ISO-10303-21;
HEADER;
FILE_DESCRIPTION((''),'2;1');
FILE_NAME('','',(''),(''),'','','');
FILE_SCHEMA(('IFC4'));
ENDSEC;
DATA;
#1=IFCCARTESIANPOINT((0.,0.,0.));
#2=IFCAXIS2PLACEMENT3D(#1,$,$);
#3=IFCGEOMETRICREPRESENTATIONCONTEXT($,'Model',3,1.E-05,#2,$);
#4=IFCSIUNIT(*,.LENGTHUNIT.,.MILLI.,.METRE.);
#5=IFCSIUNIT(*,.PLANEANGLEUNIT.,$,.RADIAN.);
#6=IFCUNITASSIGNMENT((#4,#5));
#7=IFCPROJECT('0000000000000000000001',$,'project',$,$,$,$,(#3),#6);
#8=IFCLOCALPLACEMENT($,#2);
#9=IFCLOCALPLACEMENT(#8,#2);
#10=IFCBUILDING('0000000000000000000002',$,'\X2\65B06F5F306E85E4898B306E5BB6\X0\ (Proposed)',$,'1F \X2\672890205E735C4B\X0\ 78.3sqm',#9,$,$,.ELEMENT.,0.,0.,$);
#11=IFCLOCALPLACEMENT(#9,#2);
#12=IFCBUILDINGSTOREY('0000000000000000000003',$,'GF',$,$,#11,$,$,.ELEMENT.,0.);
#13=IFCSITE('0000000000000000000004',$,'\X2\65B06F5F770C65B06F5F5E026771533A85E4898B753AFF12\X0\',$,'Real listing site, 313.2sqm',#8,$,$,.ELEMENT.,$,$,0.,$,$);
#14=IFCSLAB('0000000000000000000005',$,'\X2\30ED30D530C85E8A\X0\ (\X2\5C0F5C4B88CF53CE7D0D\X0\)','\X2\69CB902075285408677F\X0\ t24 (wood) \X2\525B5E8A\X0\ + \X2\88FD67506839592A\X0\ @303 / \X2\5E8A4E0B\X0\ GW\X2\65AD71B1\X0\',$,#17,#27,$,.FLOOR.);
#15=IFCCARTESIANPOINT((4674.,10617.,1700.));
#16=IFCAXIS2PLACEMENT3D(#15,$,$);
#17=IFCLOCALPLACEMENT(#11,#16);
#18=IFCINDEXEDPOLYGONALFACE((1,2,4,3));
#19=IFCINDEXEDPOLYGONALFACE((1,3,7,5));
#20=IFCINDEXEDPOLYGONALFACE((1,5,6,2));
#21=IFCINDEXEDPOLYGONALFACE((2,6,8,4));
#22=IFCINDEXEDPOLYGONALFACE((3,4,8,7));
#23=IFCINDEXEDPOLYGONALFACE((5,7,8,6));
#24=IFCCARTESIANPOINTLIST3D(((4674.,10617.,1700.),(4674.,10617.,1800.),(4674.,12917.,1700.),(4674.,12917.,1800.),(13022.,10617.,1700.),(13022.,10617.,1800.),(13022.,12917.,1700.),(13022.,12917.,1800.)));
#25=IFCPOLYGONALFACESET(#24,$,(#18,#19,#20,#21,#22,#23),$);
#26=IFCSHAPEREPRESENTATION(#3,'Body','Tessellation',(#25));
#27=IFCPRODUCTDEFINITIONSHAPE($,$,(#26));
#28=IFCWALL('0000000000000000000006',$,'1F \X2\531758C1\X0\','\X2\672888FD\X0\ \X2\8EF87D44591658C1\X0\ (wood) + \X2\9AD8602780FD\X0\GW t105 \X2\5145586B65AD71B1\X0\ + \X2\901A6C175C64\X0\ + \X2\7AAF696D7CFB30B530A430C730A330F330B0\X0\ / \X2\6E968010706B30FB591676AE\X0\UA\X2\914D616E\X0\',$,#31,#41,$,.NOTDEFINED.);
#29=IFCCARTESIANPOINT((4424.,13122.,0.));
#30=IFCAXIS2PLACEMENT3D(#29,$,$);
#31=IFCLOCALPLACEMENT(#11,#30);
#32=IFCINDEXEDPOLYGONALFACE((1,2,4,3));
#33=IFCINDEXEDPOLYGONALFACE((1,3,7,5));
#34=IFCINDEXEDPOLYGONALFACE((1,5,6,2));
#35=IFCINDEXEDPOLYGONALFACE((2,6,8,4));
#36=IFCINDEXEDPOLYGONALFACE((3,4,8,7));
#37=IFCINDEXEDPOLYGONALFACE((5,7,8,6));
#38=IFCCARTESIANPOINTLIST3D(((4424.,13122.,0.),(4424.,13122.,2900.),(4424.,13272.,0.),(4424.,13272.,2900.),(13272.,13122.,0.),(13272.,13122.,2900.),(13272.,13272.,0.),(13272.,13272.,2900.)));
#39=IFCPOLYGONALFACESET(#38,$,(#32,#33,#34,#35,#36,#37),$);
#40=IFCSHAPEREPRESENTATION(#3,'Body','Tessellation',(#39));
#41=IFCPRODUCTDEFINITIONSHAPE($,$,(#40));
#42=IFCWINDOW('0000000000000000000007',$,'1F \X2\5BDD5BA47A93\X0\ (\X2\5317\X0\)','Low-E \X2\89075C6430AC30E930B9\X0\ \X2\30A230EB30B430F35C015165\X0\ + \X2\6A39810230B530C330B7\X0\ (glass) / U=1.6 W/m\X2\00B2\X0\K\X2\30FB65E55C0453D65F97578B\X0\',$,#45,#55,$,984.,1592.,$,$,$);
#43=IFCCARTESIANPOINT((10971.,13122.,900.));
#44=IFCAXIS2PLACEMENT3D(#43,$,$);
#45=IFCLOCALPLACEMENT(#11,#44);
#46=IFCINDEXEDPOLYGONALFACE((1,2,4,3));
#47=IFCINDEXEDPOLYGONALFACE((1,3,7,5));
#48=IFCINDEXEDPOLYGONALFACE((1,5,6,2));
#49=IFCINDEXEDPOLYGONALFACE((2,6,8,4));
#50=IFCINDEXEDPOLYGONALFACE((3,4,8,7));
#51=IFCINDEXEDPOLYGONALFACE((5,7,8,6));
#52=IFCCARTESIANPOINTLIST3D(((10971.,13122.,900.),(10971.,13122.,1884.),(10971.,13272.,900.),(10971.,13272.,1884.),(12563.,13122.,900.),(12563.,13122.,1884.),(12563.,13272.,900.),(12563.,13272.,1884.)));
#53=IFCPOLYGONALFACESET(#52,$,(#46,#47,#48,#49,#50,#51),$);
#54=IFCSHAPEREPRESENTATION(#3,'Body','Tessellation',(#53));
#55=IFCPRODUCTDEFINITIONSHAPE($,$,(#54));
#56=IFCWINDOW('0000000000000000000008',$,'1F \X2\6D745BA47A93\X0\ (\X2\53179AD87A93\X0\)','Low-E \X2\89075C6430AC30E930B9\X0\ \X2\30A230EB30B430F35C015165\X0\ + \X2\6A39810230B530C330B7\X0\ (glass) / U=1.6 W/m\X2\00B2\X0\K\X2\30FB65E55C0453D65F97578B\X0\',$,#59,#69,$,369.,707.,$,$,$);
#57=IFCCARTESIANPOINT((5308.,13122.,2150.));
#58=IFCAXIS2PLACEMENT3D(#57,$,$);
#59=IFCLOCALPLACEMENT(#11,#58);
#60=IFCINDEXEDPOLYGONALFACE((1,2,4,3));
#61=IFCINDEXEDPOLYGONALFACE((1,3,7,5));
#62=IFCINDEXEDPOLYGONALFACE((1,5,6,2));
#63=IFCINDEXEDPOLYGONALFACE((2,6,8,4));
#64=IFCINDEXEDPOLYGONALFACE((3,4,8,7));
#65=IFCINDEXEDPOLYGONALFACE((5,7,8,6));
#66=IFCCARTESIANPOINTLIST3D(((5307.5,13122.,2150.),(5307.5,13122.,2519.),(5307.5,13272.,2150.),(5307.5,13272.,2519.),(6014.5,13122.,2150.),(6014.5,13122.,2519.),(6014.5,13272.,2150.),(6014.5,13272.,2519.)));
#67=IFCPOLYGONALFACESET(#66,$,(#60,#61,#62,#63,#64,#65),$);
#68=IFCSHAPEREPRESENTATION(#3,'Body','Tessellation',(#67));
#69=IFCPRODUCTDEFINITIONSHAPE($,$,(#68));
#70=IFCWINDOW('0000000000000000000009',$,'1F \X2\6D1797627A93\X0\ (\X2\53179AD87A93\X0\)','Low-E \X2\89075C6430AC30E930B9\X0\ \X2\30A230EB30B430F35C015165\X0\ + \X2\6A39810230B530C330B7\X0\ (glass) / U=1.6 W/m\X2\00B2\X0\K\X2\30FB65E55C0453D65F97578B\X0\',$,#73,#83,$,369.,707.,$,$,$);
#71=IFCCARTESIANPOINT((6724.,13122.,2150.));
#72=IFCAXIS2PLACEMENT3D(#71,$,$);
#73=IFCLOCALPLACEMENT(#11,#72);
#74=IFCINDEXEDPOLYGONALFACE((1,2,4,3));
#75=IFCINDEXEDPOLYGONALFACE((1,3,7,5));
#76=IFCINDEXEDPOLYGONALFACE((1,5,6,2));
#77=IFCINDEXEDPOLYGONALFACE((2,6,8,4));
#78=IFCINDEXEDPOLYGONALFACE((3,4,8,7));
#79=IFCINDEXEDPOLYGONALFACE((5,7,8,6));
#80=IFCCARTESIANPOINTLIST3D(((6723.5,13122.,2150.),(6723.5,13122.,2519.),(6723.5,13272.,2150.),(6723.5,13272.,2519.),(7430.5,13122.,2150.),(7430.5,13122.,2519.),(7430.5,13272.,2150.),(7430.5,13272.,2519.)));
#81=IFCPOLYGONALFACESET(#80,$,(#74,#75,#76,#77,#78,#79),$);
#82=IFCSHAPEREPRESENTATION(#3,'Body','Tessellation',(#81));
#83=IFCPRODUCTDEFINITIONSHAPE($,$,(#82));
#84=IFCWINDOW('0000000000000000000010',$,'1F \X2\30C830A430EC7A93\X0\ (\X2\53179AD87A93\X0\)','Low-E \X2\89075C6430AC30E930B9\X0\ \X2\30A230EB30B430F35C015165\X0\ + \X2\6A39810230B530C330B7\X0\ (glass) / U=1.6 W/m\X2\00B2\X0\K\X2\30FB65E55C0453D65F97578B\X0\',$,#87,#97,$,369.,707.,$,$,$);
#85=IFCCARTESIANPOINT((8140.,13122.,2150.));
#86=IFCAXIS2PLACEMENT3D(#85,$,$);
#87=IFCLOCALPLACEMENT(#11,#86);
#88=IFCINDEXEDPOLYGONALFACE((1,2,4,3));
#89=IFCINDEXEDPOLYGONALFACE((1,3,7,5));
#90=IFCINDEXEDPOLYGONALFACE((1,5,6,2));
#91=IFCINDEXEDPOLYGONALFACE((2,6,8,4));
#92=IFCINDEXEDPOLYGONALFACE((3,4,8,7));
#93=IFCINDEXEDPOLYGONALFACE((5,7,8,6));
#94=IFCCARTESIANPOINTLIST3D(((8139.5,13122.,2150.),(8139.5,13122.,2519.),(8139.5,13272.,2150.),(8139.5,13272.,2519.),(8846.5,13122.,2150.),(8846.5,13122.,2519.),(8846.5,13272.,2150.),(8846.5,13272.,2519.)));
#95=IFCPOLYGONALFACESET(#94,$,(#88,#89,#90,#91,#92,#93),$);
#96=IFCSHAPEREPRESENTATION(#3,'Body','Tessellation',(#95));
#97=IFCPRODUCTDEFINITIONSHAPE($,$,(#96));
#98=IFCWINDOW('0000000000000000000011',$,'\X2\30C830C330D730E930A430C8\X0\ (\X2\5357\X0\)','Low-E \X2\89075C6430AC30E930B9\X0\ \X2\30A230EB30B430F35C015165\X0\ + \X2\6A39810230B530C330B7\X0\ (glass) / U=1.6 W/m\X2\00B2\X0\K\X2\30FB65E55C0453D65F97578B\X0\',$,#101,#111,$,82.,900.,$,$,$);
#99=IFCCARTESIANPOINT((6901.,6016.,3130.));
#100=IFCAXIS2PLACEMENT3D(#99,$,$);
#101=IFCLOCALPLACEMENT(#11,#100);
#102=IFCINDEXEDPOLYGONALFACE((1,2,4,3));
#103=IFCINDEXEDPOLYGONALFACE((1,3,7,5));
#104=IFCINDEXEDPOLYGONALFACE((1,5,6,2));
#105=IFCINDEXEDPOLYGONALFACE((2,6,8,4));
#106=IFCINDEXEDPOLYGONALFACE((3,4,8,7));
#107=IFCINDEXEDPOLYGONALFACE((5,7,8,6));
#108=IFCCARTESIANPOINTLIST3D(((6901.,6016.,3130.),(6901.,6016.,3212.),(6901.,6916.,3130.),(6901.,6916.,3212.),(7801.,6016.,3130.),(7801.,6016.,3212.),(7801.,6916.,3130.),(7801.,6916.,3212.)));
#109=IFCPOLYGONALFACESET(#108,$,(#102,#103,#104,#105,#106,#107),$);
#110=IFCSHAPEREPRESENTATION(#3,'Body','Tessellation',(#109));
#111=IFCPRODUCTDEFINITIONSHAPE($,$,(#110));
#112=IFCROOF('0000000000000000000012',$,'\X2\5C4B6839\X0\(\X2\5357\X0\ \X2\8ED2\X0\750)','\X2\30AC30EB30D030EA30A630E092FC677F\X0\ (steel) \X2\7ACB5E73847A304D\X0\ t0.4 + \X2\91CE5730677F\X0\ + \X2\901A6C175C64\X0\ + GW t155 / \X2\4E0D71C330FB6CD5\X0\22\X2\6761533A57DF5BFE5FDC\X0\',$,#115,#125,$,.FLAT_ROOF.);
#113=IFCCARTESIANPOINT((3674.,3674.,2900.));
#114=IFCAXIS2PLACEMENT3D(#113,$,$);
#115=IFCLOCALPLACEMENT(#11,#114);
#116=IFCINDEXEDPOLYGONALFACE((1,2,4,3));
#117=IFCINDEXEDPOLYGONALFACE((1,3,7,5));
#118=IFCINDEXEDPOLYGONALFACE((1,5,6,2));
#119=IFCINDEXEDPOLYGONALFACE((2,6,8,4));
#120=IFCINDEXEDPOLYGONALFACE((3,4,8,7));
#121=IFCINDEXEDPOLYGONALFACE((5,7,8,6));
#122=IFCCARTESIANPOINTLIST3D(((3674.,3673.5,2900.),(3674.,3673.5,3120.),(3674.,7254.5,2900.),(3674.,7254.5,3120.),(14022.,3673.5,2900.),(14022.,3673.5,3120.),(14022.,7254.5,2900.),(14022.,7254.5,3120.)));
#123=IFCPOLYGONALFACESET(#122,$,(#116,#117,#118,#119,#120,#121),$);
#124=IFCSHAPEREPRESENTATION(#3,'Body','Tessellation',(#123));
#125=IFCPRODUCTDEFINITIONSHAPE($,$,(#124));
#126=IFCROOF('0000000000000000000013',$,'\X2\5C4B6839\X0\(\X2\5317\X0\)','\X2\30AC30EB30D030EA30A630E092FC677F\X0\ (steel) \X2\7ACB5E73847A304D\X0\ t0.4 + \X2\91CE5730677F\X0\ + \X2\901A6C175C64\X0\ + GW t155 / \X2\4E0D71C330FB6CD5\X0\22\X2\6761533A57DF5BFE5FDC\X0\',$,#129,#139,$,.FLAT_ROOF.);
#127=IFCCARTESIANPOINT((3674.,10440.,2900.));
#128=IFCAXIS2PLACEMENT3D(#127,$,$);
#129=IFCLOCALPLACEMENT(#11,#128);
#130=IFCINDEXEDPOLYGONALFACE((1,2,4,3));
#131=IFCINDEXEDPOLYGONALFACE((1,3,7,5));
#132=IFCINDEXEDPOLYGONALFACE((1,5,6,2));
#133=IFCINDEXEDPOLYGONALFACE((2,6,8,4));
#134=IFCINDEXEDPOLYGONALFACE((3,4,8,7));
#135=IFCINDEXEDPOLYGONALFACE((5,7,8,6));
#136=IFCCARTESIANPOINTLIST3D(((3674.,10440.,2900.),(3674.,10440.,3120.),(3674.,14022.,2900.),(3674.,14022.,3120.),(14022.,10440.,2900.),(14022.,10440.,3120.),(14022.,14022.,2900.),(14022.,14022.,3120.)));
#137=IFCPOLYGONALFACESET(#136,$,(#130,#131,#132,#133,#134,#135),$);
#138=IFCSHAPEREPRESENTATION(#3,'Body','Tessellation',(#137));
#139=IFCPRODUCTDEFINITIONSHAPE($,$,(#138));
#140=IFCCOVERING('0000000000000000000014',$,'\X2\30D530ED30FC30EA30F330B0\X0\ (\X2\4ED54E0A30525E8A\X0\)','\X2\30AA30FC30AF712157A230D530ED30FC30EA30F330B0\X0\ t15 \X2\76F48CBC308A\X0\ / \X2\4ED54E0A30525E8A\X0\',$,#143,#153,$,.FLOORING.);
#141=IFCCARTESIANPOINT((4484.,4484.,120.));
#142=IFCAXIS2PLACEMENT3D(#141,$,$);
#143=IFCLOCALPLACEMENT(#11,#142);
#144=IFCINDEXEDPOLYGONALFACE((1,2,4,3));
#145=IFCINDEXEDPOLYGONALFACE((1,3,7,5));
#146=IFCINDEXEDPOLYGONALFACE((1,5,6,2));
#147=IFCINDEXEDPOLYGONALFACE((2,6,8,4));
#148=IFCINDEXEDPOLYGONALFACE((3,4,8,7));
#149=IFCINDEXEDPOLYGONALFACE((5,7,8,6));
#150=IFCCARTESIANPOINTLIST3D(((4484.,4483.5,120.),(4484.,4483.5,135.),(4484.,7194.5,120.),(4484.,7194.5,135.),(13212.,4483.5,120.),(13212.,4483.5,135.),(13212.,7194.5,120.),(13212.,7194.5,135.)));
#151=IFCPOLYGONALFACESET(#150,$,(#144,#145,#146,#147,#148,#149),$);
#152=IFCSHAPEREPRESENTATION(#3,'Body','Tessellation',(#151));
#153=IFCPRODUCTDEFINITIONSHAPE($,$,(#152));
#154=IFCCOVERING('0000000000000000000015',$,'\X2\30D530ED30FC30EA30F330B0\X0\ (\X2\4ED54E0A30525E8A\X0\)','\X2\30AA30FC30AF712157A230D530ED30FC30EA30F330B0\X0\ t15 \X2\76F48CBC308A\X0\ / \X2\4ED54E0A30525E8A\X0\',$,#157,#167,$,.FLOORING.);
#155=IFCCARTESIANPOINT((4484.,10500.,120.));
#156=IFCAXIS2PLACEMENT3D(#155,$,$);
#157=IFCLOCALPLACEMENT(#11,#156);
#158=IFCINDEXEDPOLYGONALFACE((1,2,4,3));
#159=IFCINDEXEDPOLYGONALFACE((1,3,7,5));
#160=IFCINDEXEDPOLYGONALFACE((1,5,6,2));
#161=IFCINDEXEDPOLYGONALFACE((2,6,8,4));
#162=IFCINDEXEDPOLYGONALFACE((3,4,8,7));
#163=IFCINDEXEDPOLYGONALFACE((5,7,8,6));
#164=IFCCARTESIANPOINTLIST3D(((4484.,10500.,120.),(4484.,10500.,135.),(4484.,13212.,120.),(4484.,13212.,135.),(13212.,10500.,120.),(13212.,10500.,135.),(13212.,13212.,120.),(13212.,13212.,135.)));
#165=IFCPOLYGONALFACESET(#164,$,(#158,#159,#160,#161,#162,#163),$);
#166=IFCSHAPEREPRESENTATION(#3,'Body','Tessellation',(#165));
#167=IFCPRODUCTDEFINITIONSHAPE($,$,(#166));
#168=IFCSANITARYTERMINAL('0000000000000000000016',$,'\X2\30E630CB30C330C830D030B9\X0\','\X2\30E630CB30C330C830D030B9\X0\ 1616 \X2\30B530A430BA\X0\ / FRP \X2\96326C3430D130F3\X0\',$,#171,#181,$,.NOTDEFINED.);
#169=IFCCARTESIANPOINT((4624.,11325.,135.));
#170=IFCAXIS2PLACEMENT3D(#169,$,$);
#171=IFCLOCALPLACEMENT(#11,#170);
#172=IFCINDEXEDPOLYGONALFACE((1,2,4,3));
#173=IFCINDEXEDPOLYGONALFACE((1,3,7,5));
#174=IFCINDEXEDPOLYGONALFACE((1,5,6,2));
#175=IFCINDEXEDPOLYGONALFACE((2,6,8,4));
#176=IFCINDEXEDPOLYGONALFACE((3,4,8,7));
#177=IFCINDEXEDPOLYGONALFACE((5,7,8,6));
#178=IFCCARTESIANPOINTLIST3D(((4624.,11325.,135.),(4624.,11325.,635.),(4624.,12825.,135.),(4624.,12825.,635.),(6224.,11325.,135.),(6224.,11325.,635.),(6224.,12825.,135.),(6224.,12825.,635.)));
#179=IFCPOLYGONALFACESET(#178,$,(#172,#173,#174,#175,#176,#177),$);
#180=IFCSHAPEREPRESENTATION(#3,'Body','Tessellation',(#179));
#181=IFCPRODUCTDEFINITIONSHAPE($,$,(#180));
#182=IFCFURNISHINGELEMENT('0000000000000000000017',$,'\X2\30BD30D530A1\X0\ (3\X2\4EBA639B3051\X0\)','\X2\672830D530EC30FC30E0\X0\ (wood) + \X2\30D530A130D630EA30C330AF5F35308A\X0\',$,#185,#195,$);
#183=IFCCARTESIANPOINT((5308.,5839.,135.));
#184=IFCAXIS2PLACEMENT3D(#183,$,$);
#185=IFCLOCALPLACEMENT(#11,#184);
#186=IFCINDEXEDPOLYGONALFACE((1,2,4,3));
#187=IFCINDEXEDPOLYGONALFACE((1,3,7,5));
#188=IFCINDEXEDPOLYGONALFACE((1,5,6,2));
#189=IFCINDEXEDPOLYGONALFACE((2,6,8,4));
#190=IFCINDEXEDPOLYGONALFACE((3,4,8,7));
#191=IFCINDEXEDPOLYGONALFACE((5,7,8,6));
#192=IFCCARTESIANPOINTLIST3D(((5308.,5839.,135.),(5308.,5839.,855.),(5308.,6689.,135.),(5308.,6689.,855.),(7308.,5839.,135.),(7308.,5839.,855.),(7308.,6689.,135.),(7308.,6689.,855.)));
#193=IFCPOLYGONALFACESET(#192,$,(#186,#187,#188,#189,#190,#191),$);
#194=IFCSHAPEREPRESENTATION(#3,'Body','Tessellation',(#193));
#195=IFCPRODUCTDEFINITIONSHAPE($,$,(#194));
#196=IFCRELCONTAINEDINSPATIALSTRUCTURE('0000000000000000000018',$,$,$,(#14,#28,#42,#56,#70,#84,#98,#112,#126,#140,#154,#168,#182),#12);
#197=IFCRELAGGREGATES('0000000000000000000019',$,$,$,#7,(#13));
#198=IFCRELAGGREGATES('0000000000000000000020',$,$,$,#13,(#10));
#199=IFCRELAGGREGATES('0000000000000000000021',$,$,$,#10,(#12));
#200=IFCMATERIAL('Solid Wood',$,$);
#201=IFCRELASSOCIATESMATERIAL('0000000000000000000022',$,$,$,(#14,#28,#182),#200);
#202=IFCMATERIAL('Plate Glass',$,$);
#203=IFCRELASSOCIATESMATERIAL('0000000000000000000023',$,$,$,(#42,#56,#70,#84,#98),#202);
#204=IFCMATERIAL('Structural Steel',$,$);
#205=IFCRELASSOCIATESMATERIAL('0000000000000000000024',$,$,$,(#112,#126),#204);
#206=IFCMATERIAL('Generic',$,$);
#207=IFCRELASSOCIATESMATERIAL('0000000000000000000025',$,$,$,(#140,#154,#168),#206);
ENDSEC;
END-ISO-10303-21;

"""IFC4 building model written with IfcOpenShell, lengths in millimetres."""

from ifc_helpers import new_model, si_unit, frame, frame_2d, origin, place, context, project, spatial, rectangle, extrude, material, element, fill, save


model = new_model("IFC4")

# Units and contexts
model_context = context("Model", 3, precision=1e-05, world=origin())
ifc_project = project(units=[si_unit("LENGTHUNIT", "METRE", prefix="MILLI"), si_unit("PLANEANGLEUNIT", "RADIAN")], contexts=[model_context])

# Site, building, storey
site_placement = place(None, origin())
site = spatial("IfcSite", under=ifc_project, at=site_placement, Name="新潟県新潟市東区藤見町２", ObjectType="Real listing site, 313.2sqm", CompositionType="ELEMENT", RefElevation=0.0)
building_placement = place(site_placement, origin())
building = spatial("IfcBuilding", under=site, at=building_placement, Name="新潟の藤見の家 (Proposed)", ObjectType="1F 木造平屋 78.3sqm", CompositionType="ELEMENT", ElevationOfRefHeight=0.0, ElevationOfTerrain=0.0)
storey_placement = place(building_placement, origin())
storey = spatial("IfcBuildingStorey", under=building, at=storey_placement, Name="GF", CompositionType="ELEMENT", Elevation=0.0)

# Slab
ifc_material_1 = material(Name="Solid Wood")
slab_1_placement = place(storey_placement, frame((4674.0, 10617.0, 1700.0)))
element("IfcSlab", 1, at=slab_1_placement, inside=storey, material=ifc_material_1, Name="ロフト床 (小屋裏収納)", Description="構造用合板 t24 (wood) 剛床 + 製材根太 @303 / 床下 GW断熱", PredefinedType="FLOOR", context=model_context, shape_type="SweptSolid", body=[
    extrude(rectangle(XDim=8348.0, YDim=2300.0, at=frame_2d((4174.0, 1150.0))), frame((4674.0, 10617.0, 1700.0)), (0.0, 0.0, 1.0), 100.0),
])

# Shared definitions
ifc_material_2 = material(Name="Plate Glass")

# Wall, openings, windows
wall_1_placement = place(storey_placement, frame((4424.0, 13122.0, 0.0)))
wall_1 = element("IfcWall", 2, at=wall_1_placement, inside=storey, material=ifc_material_1, Name="1F 北壁", Description="木製 軸組外壁 (wood) + 高性能GW t105 充填断熱 + 通気層 + 窯業系サイディング / 準耐火・外皮UA配慮", PredefinedType="NOTDEFINED", context=model_context, shape_type="SweptSolid", body=[
    extrude(rectangle(XDim=8848.0, YDim=150.0, at=frame_2d((4424.0, 75.0))), frame((4424.0, 13122.0, 0.0)), (0.0, 0.0, 1.0), 2900.0),
])
opening_1_placement = place(storey_placement, frame((10971.0, 13122.0, 900.0)))
opening_1 = element("IfcOpeningElement", 3, at=opening_1_placement, cuts=wall_1, PredefinedType="NOTDEFINED", context=model_context, shape_type="SweptSolid", body=[
    extrude(rectangle(XDim=1592.0, YDim=150.0, at=frame_2d((796.0, 75.0))), frame((10971.0, 13122.0, 900.0)), (0.0, 0.0, 1.0), 984.0),
])
opening_2_placement = place(storey_placement, frame((5308.0, 13122.0, 2150.0)))
opening_2 = element("IfcOpeningElement", 4, at=opening_2_placement, cuts=wall_1, PredefinedType="NOTDEFINED", context=model_context, shape_type="SweptSolid", body=[
    extrude(rectangle(XDim=707.0, YDim=150.0, at=frame_2d((353.0, 75.0))), frame((5308.0, 13122.0, 2150.0)), (0.0, 0.0, 1.0), 369.0),
])
opening_3_placement = place(storey_placement, frame((6724.0, 13122.0, 2150.0)))
opening_3 = element("IfcOpeningElement", 5, at=opening_3_placement, cuts=wall_1, PredefinedType="NOTDEFINED", context=model_context, shape_type="SweptSolid", body=[
    extrude(rectangle(XDim=707.0, YDim=150.0, at=frame_2d((353.0, 75.0))), frame((6724.0, 13122.0, 2150.0)), (0.0, 0.0, 1.0), 369.0),
])
opening_4_placement = place(storey_placement, frame((8140.0, 13122.0, 2150.0)))
opening_4 = element("IfcOpeningElement", 6, at=opening_4_placement, cuts=wall_1, PredefinedType="NOTDEFINED", context=model_context, shape_type="SweptSolid", body=[
    extrude(rectangle(XDim=707.0, YDim=150.0, at=frame_2d((353.0, 75.0))), frame((8140.0, 13122.0, 2150.0)), (0.0, 0.0, 1.0), 369.0),
])
window_1_placement = place(storey_placement, frame((10971.0, 13122.0, 900.0)))
window_1 = element("IfcWindow", 7, at=window_1_placement, inside=storey, material=ifc_material_2, Name="1F 寝室窓 (北)", Description="Low-E 複層ガラス アルゴン封入 + 樹脂サッシ (glass) / U=1.6 W/m²K・日射取得型", OverallHeight=984.0, OverallWidth=1592.0, context=model_context, shape_type="SweptSolid", body=[
    extrude(rectangle(XDim=1592.0, YDim=150.0, at=frame_2d((796.0, 75.0))), frame((10971.0, 13122.0, 900.0)), (0.0, 0.0, 1.0), 984.0),
])
fill(opening_1, window_1)
window_2_placement = place(storey_placement, frame((5308.0, 13122.0, 2150.0)))
window_2 = element("IfcWindow", 8, at=window_2_placement, inside=storey, material=ifc_material_2, Name="1F 浴室窓 (北高窓)", Description="Low-E 複層ガラス アルゴン封入 + 樹脂サッシ (glass) / U=1.6 W/m²K・日射取得型", OverallHeight=369.0, OverallWidth=707.0, context=model_context, shape_type="SweptSolid", body=[
    extrude(rectangle(XDim=707.0, YDim=150.0, at=frame_2d((353.0, 75.0))), frame((5308.0, 13122.0, 2150.0)), (0.0, 0.0, 1.0), 369.0),
])
fill(opening_2, window_2)
window_3_placement = place(storey_placement, frame((6724.0, 13122.0, 2150.0)))
window_3 = element("IfcWindow", 9, at=window_3_placement, inside=storey, material=ifc_material_2, Name="1F 洗面窓 (北高窓)", Description="Low-E 複層ガラス アルゴン封入 + 樹脂サッシ (glass) / U=1.6 W/m²K・日射取得型", OverallHeight=369.0, OverallWidth=707.0, context=model_context, shape_type="SweptSolid", body=[
    extrude(rectangle(XDim=707.0, YDim=150.0, at=frame_2d((353.0, 75.0))), frame((6724.0, 13122.0, 2150.0)), (0.0, 0.0, 1.0), 369.0),
])
fill(opening_3, window_3)
window_4_placement = place(storey_placement, frame((8140.0, 13122.0, 2150.0)))
window_4 = element("IfcWindow", 10, at=window_4_placement, inside=storey, material=ifc_material_2, Name="1F トイレ窓 (北高窓)", Description="Low-E 複層ガラス アルゴン封入 + 樹脂サッシ (glass) / U=1.6 W/m²K・日射取得型", OverallHeight=369.0, OverallWidth=707.0, context=model_context, shape_type="SweptSolid", body=[
    extrude(rectangle(XDim=707.0, YDim=150.0, at=frame_2d((353.0, 75.0))), frame((8140.0, 13122.0, 2150.0)), (0.0, 0.0, 1.0), 369.0),
])
fill(opening_4, window_4)

# Window
window_5_placement = place(storey_placement, frame((6901.0, 6016.0, 3130.0)))
element("IfcWindow", 11, at=window_5_placement, inside=storey, material=ifc_material_2, Name="トップライト (南)", Description="Low-E 複層ガラス アルゴン封入 + 樹脂サッシ (glass) / U=1.6 W/m²K・日射取得型", OverallHeight=82.0, OverallWidth=900.0, context=model_context, shape_type="SweptSolid", body=[
    extrude(rectangle(XDim=900.0, YDim=900.0, at=frame_2d((450.0, 450.0))), frame((6901.0, 6016.0, 3130.0)), (0.0, 0.0, 1.0), 82.0),
])

# Roofs
ifc_material_3 = material(Name="Structural Steel")
roof_1_placement = place(storey_placement, frame((3674.0, 3674.0, 2900.0)))
element("IfcRoof", 12, at=roof_1_placement, inside=storey, material=ifc_material_3, Name="屋根(南 軒750)", Description="ガルバリウム鋼板 (steel) 立平葺き t0.4 + 野地板 + 通気層 + GW t155 / 不燃・法22条区域対応", PredefinedType="FLAT_ROOF", context=model_context, shape_type="SweptSolid", body=[
    extrude(rectangle(XDim=10348.0, YDim=3581.0, at=frame_2d((5174.0, 1790.0))), frame((3674.0, 3674.0, 2900.0)), (0.0, 0.0, 1.0), 220.0),
])
roof_2_placement = place(storey_placement, frame((3674.0, 10440.0, 2900.0)))
element("IfcRoof", 13, at=roof_2_placement, inside=storey, material=ifc_material_3, Name="屋根(北)", Description="ガルバリウム鋼板 (steel) 立平葺き t0.4 + 野地板 + 通気層 + GW t155 / 不燃・法22条区域対応", PredefinedType="FLAT_ROOF", context=model_context, shape_type="SweptSolid", body=[
    extrude(rectangle(XDim=10348.0, YDim=3582.0, at=frame_2d((5174.0, 1791.0))), frame((3674.0, 10440.0, 2900.0)), (0.0, 0.0, 1.0), 220.0),
])

# Coverings
ifc_material_4 = material(Name="Generic")
covering_1_placement = place(storey_placement, frame((4484.0, 4484.0, 120.0)))
element("IfcCovering", 14, at=covering_1_placement, inside=storey, material=ifc_material_4, Name="フローリング (仕上げ床)", Description="オーク無垢フローリング t15 直貼り / 仕上げ床", PredefinedType="FLOORING", context=model_context, shape_type="SweptSolid", body=[
    extrude(rectangle(XDim=8728.0, YDim=2711.0, at=frame_2d((4364.0, 1355.0))), frame((4484.0, 4484.0, 120.0)), (0.0, 0.0, 1.0), 15.0),
])
covering_2_placement = place(storey_placement, frame((4484.0, 10500.0, 120.0)))
element("IfcCovering", 15, at=covering_2_placement, inside=storey, material=ifc_material_4, Name="フローリング (仕上げ床)", Description="オーク無垢フローリング t15 直貼り / 仕上げ床", PredefinedType="FLOORING", context=model_context, shape_type="SweptSolid", body=[
    extrude(rectangle(XDim=8728.0, YDim=2712.0, at=frame_2d((4364.0, 1356.0))), frame((4484.0, 10500.0, 120.0)), (0.0, 0.0, 1.0), 15.0),
])

# Sanitary terminal
sanitary_terminal_placement = place(storey_placement, frame((4624.0, 11325.0, 135.0)))
element("IfcSanitaryTerminal", 16, at=sanitary_terminal_placement, inside=storey, material=ifc_material_4, Name="ユニットバス", Description="ユニットバス 1616 サイズ / FRP 防水パン", PredefinedType="NOTDEFINED", context=model_context, shape_type="SweptSolid", body=[
    extrude(rectangle(XDim=1600.0, YDim=1500.0, at=frame_2d((800.0, 750.0))), frame((4624.0, 11325.0, 135.0)), (0.0, 0.0, 1.0), 500.0),
])

# Furnishing element
furnishing_1_placement = place(storey_placement, frame((5308.0, 5839.0, 135.0)))
element("IfcFurnishingElement", 17, at=furnishing_1_placement, inside=storey, material=ifc_material_1, Name="ソファ (3人掛け)", Description="木フレーム (wood) + ファブリック張り", context=model_context, shape_type="SweptSolid", body=[
    extrude(rectangle(XDim=2000.0, YDim=850.0, at=frame_2d((1000.0, 425.0))), frame((5308.0, 5839.0, 135.0)), (0.0, 0.0, 1.0), 720.0),
])

save(model, "model.ifc")
